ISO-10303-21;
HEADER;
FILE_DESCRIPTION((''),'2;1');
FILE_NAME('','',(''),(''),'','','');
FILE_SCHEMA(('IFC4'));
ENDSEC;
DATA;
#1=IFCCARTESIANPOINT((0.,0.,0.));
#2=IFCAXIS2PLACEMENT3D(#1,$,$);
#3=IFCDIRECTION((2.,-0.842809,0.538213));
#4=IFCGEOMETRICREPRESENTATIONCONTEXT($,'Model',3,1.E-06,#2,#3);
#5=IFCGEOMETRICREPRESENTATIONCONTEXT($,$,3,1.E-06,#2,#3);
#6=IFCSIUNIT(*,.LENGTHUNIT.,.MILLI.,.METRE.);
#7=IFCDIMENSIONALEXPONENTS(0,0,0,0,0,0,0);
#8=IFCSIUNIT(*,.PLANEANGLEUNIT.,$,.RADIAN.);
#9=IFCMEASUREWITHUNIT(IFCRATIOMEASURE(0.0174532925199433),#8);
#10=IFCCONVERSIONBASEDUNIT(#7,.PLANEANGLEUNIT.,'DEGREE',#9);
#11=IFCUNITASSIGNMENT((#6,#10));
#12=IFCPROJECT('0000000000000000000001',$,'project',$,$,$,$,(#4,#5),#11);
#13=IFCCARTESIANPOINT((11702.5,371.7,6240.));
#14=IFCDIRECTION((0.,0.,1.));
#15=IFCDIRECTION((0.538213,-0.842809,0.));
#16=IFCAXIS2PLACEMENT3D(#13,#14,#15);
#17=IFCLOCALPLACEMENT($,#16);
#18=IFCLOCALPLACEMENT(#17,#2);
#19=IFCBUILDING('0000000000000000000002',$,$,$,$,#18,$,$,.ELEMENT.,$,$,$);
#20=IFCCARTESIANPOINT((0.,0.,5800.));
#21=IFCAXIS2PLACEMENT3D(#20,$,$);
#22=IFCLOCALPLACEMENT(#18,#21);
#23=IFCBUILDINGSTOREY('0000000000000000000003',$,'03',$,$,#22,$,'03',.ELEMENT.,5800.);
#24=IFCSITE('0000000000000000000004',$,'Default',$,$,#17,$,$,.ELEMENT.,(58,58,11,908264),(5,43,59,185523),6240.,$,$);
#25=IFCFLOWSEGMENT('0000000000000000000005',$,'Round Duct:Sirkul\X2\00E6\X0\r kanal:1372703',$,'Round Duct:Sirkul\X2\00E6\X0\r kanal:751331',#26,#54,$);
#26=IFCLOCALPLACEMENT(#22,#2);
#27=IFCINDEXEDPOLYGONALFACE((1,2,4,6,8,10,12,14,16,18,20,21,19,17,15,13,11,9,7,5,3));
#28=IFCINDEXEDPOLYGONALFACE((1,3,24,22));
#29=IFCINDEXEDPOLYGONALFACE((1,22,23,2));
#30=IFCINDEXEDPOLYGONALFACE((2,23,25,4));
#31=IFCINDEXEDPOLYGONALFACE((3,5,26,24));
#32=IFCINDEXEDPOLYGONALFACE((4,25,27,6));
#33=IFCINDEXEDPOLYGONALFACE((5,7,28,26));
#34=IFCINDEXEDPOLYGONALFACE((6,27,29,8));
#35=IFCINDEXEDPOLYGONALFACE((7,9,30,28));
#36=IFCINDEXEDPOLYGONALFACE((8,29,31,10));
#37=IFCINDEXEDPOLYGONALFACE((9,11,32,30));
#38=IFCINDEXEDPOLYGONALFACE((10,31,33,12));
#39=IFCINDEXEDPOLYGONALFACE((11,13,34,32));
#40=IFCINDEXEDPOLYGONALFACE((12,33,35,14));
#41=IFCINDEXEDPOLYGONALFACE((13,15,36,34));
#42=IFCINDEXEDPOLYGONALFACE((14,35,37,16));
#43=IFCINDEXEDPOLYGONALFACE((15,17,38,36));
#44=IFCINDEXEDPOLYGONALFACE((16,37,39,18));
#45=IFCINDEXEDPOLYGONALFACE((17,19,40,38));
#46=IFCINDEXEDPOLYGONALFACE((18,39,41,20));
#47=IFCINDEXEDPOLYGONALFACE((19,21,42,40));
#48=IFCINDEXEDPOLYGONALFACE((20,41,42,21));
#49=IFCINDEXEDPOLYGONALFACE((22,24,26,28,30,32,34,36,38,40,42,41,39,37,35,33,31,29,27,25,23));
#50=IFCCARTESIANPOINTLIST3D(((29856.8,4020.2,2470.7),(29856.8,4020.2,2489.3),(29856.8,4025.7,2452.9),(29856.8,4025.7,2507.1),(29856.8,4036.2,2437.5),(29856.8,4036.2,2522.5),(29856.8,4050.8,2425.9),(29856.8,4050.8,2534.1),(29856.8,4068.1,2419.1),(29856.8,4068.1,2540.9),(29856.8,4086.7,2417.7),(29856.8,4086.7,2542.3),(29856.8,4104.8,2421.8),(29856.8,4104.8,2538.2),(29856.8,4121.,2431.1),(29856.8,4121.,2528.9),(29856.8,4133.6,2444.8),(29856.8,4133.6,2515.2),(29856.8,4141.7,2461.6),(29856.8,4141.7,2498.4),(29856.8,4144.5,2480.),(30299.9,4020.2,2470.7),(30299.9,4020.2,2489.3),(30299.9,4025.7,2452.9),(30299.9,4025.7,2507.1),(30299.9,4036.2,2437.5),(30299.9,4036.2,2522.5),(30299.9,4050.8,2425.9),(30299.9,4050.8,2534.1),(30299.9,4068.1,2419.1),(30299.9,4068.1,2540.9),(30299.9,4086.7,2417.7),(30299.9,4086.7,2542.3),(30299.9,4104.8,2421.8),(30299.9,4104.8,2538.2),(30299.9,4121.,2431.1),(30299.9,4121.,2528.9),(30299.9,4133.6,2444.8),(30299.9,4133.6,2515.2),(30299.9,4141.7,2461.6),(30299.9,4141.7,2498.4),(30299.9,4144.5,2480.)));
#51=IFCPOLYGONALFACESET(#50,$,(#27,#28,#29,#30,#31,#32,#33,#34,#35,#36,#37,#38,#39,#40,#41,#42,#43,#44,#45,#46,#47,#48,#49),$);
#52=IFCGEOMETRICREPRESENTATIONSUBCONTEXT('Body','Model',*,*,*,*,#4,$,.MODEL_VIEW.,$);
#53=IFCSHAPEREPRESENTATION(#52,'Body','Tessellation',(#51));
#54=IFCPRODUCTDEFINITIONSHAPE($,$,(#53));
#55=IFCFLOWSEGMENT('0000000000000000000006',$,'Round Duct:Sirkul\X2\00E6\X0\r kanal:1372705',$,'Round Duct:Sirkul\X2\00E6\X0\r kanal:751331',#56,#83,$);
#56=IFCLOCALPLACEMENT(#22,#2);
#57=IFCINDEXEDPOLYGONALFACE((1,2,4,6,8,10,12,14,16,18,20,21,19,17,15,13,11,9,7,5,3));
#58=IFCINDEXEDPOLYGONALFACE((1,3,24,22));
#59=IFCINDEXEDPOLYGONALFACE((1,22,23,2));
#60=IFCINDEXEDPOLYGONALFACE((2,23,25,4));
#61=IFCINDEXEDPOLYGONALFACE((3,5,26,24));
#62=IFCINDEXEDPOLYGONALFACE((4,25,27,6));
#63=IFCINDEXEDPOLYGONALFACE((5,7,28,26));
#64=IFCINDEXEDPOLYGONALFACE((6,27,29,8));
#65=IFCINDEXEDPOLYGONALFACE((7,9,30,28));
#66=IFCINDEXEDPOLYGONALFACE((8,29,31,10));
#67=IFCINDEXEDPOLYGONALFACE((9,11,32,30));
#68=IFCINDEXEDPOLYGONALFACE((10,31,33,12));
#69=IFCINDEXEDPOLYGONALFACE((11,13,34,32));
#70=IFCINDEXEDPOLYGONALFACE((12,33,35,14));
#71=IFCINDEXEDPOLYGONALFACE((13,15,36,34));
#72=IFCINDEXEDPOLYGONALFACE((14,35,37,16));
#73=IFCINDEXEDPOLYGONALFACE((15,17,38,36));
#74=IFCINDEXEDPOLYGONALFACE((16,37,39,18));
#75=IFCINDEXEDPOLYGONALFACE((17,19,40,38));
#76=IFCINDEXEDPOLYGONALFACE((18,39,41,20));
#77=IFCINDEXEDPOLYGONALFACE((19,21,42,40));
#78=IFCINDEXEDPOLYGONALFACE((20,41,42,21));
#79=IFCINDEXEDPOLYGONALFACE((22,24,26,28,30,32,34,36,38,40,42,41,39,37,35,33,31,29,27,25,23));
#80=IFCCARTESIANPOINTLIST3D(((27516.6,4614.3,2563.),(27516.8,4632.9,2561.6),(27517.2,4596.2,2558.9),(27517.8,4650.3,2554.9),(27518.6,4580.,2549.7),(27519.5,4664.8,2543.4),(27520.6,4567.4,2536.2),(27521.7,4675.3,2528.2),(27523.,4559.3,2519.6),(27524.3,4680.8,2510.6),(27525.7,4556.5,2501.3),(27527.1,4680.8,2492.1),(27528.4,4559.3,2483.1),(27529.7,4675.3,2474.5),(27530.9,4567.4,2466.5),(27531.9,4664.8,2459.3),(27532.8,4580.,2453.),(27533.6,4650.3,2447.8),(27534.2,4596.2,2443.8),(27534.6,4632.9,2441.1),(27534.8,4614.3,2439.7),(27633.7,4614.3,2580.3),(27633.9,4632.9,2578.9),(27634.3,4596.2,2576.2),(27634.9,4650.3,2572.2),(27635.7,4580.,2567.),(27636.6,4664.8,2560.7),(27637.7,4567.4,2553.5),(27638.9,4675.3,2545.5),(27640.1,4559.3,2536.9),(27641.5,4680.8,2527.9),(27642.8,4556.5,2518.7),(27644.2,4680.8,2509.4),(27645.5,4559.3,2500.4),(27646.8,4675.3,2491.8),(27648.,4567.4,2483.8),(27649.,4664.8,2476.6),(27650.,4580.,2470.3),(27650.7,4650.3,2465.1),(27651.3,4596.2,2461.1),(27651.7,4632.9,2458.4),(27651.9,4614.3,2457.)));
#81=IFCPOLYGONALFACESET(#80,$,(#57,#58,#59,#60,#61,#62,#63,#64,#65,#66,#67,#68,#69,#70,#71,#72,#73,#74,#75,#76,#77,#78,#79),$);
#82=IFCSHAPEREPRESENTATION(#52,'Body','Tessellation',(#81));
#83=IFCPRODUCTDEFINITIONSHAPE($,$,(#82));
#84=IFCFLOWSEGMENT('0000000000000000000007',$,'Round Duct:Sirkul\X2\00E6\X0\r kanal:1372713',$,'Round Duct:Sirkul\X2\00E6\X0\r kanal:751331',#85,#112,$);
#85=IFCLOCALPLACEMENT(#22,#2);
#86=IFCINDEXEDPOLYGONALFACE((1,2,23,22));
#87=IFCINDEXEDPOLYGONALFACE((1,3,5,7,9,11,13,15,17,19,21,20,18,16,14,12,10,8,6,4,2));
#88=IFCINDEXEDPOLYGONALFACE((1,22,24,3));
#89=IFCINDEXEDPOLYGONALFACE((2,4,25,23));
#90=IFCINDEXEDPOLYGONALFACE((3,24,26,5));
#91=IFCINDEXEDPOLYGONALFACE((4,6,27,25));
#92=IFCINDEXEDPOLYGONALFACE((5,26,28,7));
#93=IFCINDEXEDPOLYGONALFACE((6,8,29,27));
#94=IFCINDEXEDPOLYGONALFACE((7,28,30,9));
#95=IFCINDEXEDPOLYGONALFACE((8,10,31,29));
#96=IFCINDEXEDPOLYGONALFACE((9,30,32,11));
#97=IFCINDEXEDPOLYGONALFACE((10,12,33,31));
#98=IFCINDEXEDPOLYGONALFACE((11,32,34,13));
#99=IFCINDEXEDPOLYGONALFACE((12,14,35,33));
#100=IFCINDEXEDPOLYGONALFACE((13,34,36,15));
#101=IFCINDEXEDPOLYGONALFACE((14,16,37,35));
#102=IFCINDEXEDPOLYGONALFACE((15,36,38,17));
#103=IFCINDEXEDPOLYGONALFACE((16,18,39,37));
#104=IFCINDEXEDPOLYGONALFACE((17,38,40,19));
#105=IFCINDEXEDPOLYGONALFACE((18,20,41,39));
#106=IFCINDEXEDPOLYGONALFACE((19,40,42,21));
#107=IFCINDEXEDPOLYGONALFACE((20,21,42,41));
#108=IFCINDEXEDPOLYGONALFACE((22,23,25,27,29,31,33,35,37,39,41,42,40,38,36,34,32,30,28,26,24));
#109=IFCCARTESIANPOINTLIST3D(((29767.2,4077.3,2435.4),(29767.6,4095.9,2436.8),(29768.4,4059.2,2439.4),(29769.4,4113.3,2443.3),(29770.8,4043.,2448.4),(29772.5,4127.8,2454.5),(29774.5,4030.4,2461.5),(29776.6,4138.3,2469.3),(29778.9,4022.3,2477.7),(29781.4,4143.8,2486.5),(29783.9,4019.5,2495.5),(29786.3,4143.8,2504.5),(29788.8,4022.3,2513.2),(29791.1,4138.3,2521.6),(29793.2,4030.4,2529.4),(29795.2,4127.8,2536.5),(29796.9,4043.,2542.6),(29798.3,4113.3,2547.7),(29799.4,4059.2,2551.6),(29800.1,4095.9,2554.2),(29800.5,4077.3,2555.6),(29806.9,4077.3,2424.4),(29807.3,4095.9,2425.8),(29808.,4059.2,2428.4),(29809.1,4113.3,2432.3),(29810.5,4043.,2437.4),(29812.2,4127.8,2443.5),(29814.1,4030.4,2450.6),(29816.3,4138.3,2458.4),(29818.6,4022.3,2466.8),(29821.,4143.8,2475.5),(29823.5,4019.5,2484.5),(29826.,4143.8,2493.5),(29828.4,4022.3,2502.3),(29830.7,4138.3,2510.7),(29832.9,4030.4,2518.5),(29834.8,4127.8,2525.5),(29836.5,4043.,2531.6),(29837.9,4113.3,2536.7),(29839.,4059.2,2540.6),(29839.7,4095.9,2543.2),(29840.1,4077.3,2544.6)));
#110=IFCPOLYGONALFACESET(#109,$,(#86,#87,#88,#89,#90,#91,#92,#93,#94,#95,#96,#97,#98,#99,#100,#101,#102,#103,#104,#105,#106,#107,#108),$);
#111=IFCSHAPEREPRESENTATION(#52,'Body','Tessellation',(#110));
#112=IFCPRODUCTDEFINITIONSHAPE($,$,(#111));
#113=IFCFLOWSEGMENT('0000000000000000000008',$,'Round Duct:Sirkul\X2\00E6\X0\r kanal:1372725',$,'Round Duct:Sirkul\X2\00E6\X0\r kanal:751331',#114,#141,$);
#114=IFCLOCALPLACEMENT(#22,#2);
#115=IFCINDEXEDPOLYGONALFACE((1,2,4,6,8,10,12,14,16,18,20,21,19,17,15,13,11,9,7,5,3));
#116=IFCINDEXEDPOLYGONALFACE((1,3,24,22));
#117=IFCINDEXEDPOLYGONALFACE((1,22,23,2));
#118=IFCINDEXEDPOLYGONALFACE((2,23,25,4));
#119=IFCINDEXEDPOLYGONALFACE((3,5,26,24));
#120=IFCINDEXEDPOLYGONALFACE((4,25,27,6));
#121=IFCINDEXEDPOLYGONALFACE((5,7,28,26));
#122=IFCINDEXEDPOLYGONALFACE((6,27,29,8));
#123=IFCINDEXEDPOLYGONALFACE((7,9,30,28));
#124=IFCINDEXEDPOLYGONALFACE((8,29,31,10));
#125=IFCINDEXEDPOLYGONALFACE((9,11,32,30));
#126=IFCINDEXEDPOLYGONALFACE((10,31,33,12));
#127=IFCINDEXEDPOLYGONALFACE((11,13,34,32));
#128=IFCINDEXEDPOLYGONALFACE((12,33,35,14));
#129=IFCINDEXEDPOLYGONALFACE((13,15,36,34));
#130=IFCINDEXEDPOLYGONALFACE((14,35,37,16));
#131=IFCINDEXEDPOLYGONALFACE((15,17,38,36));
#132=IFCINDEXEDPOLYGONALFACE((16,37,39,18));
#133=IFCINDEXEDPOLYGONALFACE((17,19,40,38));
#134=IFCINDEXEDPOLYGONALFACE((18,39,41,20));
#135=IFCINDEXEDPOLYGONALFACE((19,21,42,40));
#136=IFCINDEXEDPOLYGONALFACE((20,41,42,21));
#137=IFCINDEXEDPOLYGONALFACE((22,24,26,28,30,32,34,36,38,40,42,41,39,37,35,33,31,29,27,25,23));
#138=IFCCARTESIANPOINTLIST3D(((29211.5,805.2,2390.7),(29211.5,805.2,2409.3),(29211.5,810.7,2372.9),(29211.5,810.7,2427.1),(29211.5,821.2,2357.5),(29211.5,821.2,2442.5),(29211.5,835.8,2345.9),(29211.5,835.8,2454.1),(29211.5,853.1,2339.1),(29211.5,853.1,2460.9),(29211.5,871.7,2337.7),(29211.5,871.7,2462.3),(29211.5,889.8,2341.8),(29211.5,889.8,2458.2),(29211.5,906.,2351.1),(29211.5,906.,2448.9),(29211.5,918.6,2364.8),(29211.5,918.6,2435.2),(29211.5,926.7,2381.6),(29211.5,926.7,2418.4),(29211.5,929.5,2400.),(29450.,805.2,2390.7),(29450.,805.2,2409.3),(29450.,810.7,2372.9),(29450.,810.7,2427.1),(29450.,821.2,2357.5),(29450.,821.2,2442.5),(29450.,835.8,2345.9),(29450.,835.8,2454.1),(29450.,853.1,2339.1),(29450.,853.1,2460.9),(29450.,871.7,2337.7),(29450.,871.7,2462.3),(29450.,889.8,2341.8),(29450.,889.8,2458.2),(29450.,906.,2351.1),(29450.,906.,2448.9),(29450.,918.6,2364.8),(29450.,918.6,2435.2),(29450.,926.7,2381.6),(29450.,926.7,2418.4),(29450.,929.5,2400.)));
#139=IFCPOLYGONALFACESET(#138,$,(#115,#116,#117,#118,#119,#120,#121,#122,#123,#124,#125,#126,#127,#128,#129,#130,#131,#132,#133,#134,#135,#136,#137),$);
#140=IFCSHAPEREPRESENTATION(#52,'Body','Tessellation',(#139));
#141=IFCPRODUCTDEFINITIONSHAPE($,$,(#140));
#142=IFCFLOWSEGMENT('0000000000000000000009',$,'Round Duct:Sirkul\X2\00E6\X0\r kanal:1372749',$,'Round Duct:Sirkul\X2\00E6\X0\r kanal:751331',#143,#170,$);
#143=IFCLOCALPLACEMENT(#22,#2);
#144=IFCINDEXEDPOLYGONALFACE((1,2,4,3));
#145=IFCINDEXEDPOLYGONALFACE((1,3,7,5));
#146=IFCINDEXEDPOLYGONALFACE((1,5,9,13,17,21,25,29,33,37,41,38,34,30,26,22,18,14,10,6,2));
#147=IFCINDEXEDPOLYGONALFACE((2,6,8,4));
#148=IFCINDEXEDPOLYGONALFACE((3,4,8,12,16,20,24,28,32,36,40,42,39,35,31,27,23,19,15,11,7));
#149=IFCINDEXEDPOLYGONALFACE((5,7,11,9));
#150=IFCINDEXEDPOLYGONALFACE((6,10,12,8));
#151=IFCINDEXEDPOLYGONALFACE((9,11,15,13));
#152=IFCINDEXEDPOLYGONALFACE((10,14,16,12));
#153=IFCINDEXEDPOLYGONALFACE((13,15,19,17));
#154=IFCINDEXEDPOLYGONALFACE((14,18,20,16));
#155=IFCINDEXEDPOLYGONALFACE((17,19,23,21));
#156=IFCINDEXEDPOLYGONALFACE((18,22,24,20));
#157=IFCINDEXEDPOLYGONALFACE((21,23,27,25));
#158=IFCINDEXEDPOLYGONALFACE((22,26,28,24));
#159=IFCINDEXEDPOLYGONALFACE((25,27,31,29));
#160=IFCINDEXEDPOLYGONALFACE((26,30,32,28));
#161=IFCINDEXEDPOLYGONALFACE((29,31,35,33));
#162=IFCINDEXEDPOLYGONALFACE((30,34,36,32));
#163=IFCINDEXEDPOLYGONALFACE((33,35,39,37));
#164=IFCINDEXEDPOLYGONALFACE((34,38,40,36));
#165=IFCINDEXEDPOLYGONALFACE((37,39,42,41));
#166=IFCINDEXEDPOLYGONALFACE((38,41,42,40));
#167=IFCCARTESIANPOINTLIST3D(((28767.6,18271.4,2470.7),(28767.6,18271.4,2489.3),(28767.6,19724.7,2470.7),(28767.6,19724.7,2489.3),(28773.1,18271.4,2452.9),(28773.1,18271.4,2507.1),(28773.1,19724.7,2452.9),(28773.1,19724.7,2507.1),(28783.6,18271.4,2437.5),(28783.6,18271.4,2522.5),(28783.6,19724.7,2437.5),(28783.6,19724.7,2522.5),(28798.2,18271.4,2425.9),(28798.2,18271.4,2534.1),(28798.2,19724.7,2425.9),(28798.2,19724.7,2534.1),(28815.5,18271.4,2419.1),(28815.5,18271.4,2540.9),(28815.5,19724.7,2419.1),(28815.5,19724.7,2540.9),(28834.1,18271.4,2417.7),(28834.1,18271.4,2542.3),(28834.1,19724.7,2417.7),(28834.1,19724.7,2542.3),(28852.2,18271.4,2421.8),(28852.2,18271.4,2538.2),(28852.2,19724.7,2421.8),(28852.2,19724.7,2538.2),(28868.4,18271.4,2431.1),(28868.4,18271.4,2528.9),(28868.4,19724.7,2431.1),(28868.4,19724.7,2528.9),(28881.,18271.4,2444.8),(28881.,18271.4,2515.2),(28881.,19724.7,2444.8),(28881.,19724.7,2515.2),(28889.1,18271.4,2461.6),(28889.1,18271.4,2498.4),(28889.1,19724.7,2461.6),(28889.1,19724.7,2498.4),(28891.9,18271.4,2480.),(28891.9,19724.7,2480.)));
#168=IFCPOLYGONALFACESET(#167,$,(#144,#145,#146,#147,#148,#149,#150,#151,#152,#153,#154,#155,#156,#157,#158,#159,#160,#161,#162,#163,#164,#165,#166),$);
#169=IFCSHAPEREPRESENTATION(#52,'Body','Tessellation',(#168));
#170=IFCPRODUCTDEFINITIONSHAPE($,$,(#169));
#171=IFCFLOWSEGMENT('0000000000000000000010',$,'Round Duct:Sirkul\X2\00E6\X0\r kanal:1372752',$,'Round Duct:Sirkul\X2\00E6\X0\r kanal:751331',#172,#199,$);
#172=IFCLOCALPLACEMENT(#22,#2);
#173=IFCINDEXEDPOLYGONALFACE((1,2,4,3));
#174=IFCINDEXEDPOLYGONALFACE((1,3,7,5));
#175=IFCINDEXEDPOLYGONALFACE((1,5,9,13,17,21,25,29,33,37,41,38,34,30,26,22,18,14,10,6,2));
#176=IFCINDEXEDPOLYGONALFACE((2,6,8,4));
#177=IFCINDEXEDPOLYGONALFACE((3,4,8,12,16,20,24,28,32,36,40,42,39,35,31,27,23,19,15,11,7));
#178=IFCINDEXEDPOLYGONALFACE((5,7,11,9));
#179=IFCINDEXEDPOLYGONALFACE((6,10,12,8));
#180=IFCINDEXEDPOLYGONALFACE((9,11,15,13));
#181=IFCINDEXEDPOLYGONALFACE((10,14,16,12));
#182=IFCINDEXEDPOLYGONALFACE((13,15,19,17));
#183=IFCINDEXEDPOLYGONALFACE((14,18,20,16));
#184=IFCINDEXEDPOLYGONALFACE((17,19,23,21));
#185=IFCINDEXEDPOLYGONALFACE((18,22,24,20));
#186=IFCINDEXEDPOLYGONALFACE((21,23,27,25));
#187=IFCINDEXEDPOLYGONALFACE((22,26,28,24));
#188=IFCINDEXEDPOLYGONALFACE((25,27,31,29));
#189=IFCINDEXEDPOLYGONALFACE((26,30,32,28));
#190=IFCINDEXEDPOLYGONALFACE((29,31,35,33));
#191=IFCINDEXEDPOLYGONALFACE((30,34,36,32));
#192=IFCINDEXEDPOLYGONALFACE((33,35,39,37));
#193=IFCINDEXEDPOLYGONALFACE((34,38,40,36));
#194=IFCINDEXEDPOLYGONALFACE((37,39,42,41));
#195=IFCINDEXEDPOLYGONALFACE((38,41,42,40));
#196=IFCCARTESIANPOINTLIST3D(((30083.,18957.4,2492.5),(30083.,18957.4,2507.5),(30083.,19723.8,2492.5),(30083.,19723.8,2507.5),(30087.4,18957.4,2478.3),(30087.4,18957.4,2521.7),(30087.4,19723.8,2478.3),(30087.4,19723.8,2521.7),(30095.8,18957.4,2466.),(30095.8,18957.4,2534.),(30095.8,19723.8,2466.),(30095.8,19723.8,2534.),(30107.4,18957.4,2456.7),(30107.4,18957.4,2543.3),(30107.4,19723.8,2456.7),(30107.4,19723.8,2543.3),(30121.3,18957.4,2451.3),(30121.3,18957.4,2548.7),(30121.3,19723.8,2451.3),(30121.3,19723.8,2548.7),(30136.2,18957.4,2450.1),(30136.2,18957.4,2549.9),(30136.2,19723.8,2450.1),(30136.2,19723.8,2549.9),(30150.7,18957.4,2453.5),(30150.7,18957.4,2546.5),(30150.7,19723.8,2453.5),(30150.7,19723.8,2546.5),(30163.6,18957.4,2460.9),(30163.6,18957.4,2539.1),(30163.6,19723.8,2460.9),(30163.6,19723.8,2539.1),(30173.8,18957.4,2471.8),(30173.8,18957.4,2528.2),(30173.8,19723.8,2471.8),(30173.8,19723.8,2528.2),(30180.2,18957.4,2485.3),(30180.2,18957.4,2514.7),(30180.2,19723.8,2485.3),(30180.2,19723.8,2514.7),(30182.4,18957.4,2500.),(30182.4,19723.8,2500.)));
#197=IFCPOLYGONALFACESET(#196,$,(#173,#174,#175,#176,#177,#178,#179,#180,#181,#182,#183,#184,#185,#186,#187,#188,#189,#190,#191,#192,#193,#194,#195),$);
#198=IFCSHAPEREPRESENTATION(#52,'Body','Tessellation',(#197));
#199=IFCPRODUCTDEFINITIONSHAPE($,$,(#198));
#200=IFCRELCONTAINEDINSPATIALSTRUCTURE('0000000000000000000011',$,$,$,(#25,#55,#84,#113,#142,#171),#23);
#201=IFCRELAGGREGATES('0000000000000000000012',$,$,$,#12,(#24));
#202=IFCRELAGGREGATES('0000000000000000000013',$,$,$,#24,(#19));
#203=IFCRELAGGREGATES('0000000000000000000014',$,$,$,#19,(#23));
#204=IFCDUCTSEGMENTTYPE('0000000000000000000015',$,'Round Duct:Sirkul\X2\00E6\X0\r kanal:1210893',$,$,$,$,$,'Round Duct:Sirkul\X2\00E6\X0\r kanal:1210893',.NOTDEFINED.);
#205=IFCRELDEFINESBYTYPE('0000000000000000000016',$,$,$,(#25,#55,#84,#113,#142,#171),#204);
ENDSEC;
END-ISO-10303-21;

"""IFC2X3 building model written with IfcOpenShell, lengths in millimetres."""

from ifc_helpers import new_model, entity, si_unit, converted_unit, direction, frame, frame_2d, origin, origin_2d_with_axis, place, context, subcontext, project, spatial, circle, extrude, type_object, element, save


model = new_model("IFC2X3")

# Units and contexts
model_context = context("Model", 3, precision=1e-06, world=origin(), true_north=direction((2.0, -0.842809, 0.538213)))
context_of_model = context(None, 3, precision=1e-06, world=origin(), true_north=direction((2.0, -0.842809, 0.538213)))
body_context = subcontext(model_context, "Body", "Model", "MODEL_VIEW")
ifc_project = project(units=[si_unit("LENGTHUNIT", "METRE", prefix="MILLI"), converted_unit("PLANEANGLEUNIT", "DEGREE", entity("IfcRatioMeasure", 0.0174532925199433), si_unit("PLANEANGLEUNIT", "RADIAN"), dimensions=[0, 0, 0, 0, 0, 0, 0])], contexts=[model_context, context_of_model])

# Site, building, storey
site_placement = place(None, frame((11702.5, 371.7, 6240.0), z_axis=(0.0, 0.0, 1.0), x_axis=(0.538213, -0.842809, 0.0)))
site = spatial("IfcSite", under=ifc_project, at=site_placement, Name="Default", CompositionType="ELEMENT", RefLatitude=(58, 58, 11, 908264), RefLongitude=(5, 43, 59, 185523), RefElevation=6240.0)
building_placement = place(site_placement, origin())
building = spatial("IfcBuilding", under=site, at=building_placement, CompositionType="ELEMENT")
storey_placement = place(building_placement, frame((0.0, 0.0, 5800.0)))
storey = spatial("IfcBuildingStorey", under=building, at=storey_placement, Name="03", LongName="03", CompositionType="ELEMENT", Elevation=5800.0)

# Flow segments
duct_segment_type_1 = type_object("IfcDuctSegmentType", Name="Round Duct:Sirkulær kanal:1210893", ElementType="Round Duct:Sirkulær kanal:1210893", PredefinedType="NOTDEFINED")
flow_segment_1_placement = place(storey_placement, origin())
element("IfcFlowSegment", 1, at=flow_segment_1_placement, inside=storey, type_object=duct_segment_type_1, Name="Round Duct:Sirkulær kanal:1372703", ObjectType="Round Duct:Sirkulær kanal:751331", context=body_context, shape_type="SweptSolid", body=[
    extrude(circle(Radius=62.5, at=frame_2d((0.0, 0.0), x_axis=(1.0, 0.0))), frame((29856.8, 4082.0, 2480.0), z_axis=(1.0, 0.0, 0.0), x_axis=(0.0, 1.0, 0.0)), (0.0, 0.0, 1.0), 443.0),
])
flow_segment_2_placement = place(storey_placement, origin())
element("IfcFlowSegment", 2, at=flow_segment_2_placement, inside=storey, type_object=duct_segment_type_1, Name="Round Duct:Sirkulær kanal:1372705", ObjectType="Round Duct:Sirkulær kanal:751331", context=body_context, shape_type="SweptSolid", body=[
    extrude(circle(Radius=62.5, at=origin_2d_with_axis()), frame((27525.7, 4619.0, 2501.3), z_axis=(0.98925, 0.0, 0.146233), x_axis=(0.0, -1.0, 0.0)), (0.0, 0.0, 1.0), 118.4),
])
flow_segment_3_placement = place(storey_placement, origin())
element("IfcFlowSegment", 3, at=flow_segment_3_placement, inside=storey, type_object=duct_segment_type_1, Name="Round Duct:Sirkulær kanal:1372713", ObjectType="Round Duct:Sirkulær kanal:751331", context=body_context, shape_type="SweptSolid", body=[
    extrude(circle(Radius=62.5, at=frame_2d((0.0, 0.0), x_axis=(1.0, 0.0))), frame((29823.5, 4082.0, 2484.5), z_axis=(-0.963847, 0.0, 0.266455), x_axis=(0.0, -1.0, 0.0)), (0.0, 0.0, 1.0), 41.1),
])
flow_segment_4_placement = place(storey_placement, origin())
element("IfcFlowSegment", 4, at=flow_segment_4_placement, inside=storey, type_object=duct_segment_type_1, Name="Round Duct:Sirkulær kanal:1372725", ObjectType="Round Duct:Sirkulær kanal:751331", context=body_context, shape_type="SweptSolid", body=[
    extrude(circle(Radius=62.5, at=frame_2d((0.0, 0.0), x_axis=(1.0, 0.0))), frame((29211.5, 867.0, 2400.0), z_axis=(1.0, 0.0, 0.0), x_axis=(0.0, 1.0, 0.0)), (0.0, 0.0, 1.0), 238.5),
])
flow_segment_5_placement = place(storey_placement, origin())
element("IfcFlowSegment", 5, at=flow_segment_5_placement, inside=storey, type_object=duct_segment_type_1, Name="Round Duct:Sirkulær kanal:1372749", ObjectType="Round Duct:Sirkulær kanal:751331", context=body_context, shape_type="SweptSolid", body=[
    extrude(circle(Radius=62.5, at=origin_2d_with_axis()), frame((28829.4, 18271.4, 2480.0), z_axis=(0.0, 1.0, 0.0), x_axis=(1.0, 0.0, 0.0)), (0.0, 0.0, 1.0), 1453.3),
])
flow_segment_6_placement = place(storey_placement, origin())
element("IfcFlowSegment", 6, at=flow_segment_6_placement, inside=storey, type_object=duct_segment_type_1, Name="Round Duct:Sirkulær kanal:1372752", ObjectType="Round Duct:Sirkulær kanal:751331", context=body_context, shape_type="SweptSolid", body=[
    extrude(circle(Radius=50.0, at=origin_2d_with_axis()), frame((30132.4, 18957.4, 2500.0), z_axis=(0.0, 1.0, 0.0), x_axis=(1.0, 0.0, 0.0)), (0.0, 0.0, 1.0), 766.5),
])

save(model, "model.ifc")
